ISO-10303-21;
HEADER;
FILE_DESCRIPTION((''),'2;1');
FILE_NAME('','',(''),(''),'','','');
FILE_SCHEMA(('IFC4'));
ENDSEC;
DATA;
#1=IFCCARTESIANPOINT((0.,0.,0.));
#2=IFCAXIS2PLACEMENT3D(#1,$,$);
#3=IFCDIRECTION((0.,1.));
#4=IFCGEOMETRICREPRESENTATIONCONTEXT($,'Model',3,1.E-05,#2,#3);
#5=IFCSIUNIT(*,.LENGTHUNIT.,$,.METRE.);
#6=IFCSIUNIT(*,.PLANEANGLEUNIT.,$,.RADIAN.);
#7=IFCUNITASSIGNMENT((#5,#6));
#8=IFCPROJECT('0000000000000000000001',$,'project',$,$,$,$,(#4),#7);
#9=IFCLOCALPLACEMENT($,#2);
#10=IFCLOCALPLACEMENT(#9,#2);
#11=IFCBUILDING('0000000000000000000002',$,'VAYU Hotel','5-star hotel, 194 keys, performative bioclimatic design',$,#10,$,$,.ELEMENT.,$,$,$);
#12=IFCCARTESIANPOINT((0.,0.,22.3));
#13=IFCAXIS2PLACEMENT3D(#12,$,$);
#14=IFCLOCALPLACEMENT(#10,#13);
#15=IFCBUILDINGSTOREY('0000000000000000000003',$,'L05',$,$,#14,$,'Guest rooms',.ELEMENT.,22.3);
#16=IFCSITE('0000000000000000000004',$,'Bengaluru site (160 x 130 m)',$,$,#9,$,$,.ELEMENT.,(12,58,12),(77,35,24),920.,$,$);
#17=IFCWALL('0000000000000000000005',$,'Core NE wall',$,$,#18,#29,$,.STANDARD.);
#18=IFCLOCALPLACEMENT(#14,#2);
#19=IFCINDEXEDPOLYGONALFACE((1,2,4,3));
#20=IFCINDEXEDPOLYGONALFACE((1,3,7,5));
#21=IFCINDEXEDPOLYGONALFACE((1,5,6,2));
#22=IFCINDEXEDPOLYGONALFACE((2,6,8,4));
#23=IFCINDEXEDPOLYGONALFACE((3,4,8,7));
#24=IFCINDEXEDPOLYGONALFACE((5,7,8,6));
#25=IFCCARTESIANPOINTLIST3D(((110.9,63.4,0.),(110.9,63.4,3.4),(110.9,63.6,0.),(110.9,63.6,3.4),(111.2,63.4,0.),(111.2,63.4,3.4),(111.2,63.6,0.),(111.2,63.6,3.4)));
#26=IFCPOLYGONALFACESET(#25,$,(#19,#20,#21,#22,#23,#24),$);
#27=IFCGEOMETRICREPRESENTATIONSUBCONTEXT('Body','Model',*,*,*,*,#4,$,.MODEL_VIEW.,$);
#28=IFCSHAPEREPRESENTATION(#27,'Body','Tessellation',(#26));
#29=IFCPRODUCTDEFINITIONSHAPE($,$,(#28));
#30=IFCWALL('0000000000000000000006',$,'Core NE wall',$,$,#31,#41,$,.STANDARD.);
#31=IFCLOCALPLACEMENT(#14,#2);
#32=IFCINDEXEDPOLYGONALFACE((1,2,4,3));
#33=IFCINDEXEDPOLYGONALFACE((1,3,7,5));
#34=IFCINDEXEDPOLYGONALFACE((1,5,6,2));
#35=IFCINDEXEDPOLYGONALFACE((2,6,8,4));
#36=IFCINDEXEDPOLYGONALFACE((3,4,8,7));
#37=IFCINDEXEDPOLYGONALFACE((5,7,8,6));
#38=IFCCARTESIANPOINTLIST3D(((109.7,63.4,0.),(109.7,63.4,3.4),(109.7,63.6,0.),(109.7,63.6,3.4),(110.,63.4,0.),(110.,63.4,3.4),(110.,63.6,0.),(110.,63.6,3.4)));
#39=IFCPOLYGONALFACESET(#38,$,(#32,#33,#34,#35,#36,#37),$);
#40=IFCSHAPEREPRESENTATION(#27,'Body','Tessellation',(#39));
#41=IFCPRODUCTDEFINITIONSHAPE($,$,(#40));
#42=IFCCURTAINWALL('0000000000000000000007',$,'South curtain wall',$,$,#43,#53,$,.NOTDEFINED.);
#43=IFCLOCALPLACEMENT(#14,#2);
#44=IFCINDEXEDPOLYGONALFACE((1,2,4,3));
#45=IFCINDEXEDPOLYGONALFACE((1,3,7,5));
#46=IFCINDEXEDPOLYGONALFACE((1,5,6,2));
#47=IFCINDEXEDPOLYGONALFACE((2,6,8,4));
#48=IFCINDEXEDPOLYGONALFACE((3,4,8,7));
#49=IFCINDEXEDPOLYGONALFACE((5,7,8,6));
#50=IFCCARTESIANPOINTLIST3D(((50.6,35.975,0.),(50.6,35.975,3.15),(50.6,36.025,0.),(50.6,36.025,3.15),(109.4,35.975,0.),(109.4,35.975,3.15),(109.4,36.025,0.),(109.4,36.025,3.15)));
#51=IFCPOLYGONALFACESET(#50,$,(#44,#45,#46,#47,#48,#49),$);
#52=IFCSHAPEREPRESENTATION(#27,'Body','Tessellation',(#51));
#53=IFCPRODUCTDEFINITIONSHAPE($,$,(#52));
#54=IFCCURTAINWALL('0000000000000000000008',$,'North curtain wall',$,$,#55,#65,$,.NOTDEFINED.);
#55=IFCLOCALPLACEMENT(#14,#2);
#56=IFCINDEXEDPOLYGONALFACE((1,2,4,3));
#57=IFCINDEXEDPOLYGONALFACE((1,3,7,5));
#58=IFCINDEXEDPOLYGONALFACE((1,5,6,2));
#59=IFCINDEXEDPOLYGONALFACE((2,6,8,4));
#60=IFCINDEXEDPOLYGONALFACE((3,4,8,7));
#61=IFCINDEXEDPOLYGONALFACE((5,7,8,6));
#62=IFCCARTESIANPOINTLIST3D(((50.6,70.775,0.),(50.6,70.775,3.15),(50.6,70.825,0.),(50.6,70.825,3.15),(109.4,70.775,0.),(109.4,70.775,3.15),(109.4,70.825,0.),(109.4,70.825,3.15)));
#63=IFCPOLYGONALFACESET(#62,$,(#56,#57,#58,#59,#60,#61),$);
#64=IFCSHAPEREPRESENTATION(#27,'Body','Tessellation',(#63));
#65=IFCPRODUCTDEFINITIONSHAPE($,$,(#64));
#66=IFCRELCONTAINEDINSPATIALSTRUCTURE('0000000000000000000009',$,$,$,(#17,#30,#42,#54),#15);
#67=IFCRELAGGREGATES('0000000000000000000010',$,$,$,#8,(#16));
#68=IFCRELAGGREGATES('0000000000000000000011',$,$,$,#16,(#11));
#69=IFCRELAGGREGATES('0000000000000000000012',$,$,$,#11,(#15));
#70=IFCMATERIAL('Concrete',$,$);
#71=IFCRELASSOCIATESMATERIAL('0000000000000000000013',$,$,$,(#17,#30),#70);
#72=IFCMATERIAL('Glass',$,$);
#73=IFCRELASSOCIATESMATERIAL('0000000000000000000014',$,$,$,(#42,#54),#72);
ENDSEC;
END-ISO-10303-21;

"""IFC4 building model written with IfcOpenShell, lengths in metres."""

from ifc_helpers import new_model, si_unit, direction, frame, origin, place, context, subcontext, project, spatial, polyline, outline, extrude, material, element, save


model = new_model("IFC4")

# Units and contexts
model_context = context("Model", 3, precision=1e-05, world=origin(), true_north=direction((0.0, 1.0)))
body_context = subcontext(model_context, "Body", "Model", "MODEL_VIEW")
ifc_project = project(units=[si_unit("LENGTHUNIT", "METRE"), si_unit("PLANEANGLEUNIT", "RADIAN")], contexts=[model_context])

# Site, building, storey
site_placement = place(None, origin())
site = spatial("IfcSite", under=ifc_project, at=site_placement, Name="Bengaluru site (160 x 130 m)", CompositionType="ELEMENT", RefLatitude=(12, 58, 12), RefLongitude=(77, 35, 24), RefElevation=920.0)
building_placement = place(site_placement, origin())
building = spatial("IfcBuilding", under=site, at=building_placement, Name="VAYU Hotel", Description="5-star hotel, 194 keys, performative bioclimatic design", CompositionType="ELEMENT")
storey_placement = place(building_placement, frame((0.0, 0.0, 22.3)))
storey = spatial("IfcBuildingStorey", under=building, at=storey_placement, Name="L05", LongName="Guest rooms", CompositionType="ELEMENT", Elevation=22.3)

# Shared definitions
ifc_material_1 = material(Name="Concrete")

# Walls
wall_1_placement = place(storey_placement, origin())
element("IfcWall", 1, at=wall_1_placement, inside=storey, material=ifc_material_1, Name="Core NE wall", PredefinedType="STANDARD", context=body_context, shape_type="SweptSolid", body=[
    extrude(outline(polyline([(110.9, 63.6), (111.2, 63.6), (111.2, 63.4), (110.9, 63.4), (110.9, 63.6)])), origin(), (0.0, 0.0, 1.0), 3.4),
])
wall_2_placement = place(storey_placement, origin())
element("IfcWall", 2, at=wall_2_placement, inside=storey, material=ifc_material_1, Name="Core NE wall", PredefinedType="STANDARD", context=body_context, shape_type="SweptSolid", body=[
    extrude(outline(polyline([(109.7, 63.6), (110.0, 63.6), (110.0, 63.4), (109.7, 63.4), (109.7, 63.6)])), origin(), (0.0, 0.0, 1.0), 3.4),
])

# Curtain walls
ifc_material_2 = material(Name="Glass")
curtain_wall_1_placement = place(storey_placement, origin())
element("IfcCurtainWall", 3, at=curtain_wall_1_placement, inside=storey, material=ifc_material_2, Name="South curtain wall", PredefinedType="NOTDEFINED", context=body_context, shape_type="SweptSolid", body=[
    extrude(outline(polyline([(50.6, 36.025), (109.4, 36.025), (109.4, 35.975), (50.6, 35.975), (50.6, 36.025)])), origin(), (0.0, 0.0, 1.0), 3.15),
])
curtain_wall_2_placement = place(storey_placement, origin())
element("IfcCurtainWall", 4, at=curtain_wall_2_placement, inside=storey, material=ifc_material_2, Name="North curtain wall", PredefinedType="NOTDEFINED", context=body_context, shape_type="SweptSolid", body=[
    extrude(outline(polyline([(50.6, 70.825), (109.4, 70.825), (109.4, 70.775), (50.6, 70.775), (50.6, 70.825)])), origin(), (0.0, 0.0, 1.0), 3.15),
])

save(model, "model.ifc")
